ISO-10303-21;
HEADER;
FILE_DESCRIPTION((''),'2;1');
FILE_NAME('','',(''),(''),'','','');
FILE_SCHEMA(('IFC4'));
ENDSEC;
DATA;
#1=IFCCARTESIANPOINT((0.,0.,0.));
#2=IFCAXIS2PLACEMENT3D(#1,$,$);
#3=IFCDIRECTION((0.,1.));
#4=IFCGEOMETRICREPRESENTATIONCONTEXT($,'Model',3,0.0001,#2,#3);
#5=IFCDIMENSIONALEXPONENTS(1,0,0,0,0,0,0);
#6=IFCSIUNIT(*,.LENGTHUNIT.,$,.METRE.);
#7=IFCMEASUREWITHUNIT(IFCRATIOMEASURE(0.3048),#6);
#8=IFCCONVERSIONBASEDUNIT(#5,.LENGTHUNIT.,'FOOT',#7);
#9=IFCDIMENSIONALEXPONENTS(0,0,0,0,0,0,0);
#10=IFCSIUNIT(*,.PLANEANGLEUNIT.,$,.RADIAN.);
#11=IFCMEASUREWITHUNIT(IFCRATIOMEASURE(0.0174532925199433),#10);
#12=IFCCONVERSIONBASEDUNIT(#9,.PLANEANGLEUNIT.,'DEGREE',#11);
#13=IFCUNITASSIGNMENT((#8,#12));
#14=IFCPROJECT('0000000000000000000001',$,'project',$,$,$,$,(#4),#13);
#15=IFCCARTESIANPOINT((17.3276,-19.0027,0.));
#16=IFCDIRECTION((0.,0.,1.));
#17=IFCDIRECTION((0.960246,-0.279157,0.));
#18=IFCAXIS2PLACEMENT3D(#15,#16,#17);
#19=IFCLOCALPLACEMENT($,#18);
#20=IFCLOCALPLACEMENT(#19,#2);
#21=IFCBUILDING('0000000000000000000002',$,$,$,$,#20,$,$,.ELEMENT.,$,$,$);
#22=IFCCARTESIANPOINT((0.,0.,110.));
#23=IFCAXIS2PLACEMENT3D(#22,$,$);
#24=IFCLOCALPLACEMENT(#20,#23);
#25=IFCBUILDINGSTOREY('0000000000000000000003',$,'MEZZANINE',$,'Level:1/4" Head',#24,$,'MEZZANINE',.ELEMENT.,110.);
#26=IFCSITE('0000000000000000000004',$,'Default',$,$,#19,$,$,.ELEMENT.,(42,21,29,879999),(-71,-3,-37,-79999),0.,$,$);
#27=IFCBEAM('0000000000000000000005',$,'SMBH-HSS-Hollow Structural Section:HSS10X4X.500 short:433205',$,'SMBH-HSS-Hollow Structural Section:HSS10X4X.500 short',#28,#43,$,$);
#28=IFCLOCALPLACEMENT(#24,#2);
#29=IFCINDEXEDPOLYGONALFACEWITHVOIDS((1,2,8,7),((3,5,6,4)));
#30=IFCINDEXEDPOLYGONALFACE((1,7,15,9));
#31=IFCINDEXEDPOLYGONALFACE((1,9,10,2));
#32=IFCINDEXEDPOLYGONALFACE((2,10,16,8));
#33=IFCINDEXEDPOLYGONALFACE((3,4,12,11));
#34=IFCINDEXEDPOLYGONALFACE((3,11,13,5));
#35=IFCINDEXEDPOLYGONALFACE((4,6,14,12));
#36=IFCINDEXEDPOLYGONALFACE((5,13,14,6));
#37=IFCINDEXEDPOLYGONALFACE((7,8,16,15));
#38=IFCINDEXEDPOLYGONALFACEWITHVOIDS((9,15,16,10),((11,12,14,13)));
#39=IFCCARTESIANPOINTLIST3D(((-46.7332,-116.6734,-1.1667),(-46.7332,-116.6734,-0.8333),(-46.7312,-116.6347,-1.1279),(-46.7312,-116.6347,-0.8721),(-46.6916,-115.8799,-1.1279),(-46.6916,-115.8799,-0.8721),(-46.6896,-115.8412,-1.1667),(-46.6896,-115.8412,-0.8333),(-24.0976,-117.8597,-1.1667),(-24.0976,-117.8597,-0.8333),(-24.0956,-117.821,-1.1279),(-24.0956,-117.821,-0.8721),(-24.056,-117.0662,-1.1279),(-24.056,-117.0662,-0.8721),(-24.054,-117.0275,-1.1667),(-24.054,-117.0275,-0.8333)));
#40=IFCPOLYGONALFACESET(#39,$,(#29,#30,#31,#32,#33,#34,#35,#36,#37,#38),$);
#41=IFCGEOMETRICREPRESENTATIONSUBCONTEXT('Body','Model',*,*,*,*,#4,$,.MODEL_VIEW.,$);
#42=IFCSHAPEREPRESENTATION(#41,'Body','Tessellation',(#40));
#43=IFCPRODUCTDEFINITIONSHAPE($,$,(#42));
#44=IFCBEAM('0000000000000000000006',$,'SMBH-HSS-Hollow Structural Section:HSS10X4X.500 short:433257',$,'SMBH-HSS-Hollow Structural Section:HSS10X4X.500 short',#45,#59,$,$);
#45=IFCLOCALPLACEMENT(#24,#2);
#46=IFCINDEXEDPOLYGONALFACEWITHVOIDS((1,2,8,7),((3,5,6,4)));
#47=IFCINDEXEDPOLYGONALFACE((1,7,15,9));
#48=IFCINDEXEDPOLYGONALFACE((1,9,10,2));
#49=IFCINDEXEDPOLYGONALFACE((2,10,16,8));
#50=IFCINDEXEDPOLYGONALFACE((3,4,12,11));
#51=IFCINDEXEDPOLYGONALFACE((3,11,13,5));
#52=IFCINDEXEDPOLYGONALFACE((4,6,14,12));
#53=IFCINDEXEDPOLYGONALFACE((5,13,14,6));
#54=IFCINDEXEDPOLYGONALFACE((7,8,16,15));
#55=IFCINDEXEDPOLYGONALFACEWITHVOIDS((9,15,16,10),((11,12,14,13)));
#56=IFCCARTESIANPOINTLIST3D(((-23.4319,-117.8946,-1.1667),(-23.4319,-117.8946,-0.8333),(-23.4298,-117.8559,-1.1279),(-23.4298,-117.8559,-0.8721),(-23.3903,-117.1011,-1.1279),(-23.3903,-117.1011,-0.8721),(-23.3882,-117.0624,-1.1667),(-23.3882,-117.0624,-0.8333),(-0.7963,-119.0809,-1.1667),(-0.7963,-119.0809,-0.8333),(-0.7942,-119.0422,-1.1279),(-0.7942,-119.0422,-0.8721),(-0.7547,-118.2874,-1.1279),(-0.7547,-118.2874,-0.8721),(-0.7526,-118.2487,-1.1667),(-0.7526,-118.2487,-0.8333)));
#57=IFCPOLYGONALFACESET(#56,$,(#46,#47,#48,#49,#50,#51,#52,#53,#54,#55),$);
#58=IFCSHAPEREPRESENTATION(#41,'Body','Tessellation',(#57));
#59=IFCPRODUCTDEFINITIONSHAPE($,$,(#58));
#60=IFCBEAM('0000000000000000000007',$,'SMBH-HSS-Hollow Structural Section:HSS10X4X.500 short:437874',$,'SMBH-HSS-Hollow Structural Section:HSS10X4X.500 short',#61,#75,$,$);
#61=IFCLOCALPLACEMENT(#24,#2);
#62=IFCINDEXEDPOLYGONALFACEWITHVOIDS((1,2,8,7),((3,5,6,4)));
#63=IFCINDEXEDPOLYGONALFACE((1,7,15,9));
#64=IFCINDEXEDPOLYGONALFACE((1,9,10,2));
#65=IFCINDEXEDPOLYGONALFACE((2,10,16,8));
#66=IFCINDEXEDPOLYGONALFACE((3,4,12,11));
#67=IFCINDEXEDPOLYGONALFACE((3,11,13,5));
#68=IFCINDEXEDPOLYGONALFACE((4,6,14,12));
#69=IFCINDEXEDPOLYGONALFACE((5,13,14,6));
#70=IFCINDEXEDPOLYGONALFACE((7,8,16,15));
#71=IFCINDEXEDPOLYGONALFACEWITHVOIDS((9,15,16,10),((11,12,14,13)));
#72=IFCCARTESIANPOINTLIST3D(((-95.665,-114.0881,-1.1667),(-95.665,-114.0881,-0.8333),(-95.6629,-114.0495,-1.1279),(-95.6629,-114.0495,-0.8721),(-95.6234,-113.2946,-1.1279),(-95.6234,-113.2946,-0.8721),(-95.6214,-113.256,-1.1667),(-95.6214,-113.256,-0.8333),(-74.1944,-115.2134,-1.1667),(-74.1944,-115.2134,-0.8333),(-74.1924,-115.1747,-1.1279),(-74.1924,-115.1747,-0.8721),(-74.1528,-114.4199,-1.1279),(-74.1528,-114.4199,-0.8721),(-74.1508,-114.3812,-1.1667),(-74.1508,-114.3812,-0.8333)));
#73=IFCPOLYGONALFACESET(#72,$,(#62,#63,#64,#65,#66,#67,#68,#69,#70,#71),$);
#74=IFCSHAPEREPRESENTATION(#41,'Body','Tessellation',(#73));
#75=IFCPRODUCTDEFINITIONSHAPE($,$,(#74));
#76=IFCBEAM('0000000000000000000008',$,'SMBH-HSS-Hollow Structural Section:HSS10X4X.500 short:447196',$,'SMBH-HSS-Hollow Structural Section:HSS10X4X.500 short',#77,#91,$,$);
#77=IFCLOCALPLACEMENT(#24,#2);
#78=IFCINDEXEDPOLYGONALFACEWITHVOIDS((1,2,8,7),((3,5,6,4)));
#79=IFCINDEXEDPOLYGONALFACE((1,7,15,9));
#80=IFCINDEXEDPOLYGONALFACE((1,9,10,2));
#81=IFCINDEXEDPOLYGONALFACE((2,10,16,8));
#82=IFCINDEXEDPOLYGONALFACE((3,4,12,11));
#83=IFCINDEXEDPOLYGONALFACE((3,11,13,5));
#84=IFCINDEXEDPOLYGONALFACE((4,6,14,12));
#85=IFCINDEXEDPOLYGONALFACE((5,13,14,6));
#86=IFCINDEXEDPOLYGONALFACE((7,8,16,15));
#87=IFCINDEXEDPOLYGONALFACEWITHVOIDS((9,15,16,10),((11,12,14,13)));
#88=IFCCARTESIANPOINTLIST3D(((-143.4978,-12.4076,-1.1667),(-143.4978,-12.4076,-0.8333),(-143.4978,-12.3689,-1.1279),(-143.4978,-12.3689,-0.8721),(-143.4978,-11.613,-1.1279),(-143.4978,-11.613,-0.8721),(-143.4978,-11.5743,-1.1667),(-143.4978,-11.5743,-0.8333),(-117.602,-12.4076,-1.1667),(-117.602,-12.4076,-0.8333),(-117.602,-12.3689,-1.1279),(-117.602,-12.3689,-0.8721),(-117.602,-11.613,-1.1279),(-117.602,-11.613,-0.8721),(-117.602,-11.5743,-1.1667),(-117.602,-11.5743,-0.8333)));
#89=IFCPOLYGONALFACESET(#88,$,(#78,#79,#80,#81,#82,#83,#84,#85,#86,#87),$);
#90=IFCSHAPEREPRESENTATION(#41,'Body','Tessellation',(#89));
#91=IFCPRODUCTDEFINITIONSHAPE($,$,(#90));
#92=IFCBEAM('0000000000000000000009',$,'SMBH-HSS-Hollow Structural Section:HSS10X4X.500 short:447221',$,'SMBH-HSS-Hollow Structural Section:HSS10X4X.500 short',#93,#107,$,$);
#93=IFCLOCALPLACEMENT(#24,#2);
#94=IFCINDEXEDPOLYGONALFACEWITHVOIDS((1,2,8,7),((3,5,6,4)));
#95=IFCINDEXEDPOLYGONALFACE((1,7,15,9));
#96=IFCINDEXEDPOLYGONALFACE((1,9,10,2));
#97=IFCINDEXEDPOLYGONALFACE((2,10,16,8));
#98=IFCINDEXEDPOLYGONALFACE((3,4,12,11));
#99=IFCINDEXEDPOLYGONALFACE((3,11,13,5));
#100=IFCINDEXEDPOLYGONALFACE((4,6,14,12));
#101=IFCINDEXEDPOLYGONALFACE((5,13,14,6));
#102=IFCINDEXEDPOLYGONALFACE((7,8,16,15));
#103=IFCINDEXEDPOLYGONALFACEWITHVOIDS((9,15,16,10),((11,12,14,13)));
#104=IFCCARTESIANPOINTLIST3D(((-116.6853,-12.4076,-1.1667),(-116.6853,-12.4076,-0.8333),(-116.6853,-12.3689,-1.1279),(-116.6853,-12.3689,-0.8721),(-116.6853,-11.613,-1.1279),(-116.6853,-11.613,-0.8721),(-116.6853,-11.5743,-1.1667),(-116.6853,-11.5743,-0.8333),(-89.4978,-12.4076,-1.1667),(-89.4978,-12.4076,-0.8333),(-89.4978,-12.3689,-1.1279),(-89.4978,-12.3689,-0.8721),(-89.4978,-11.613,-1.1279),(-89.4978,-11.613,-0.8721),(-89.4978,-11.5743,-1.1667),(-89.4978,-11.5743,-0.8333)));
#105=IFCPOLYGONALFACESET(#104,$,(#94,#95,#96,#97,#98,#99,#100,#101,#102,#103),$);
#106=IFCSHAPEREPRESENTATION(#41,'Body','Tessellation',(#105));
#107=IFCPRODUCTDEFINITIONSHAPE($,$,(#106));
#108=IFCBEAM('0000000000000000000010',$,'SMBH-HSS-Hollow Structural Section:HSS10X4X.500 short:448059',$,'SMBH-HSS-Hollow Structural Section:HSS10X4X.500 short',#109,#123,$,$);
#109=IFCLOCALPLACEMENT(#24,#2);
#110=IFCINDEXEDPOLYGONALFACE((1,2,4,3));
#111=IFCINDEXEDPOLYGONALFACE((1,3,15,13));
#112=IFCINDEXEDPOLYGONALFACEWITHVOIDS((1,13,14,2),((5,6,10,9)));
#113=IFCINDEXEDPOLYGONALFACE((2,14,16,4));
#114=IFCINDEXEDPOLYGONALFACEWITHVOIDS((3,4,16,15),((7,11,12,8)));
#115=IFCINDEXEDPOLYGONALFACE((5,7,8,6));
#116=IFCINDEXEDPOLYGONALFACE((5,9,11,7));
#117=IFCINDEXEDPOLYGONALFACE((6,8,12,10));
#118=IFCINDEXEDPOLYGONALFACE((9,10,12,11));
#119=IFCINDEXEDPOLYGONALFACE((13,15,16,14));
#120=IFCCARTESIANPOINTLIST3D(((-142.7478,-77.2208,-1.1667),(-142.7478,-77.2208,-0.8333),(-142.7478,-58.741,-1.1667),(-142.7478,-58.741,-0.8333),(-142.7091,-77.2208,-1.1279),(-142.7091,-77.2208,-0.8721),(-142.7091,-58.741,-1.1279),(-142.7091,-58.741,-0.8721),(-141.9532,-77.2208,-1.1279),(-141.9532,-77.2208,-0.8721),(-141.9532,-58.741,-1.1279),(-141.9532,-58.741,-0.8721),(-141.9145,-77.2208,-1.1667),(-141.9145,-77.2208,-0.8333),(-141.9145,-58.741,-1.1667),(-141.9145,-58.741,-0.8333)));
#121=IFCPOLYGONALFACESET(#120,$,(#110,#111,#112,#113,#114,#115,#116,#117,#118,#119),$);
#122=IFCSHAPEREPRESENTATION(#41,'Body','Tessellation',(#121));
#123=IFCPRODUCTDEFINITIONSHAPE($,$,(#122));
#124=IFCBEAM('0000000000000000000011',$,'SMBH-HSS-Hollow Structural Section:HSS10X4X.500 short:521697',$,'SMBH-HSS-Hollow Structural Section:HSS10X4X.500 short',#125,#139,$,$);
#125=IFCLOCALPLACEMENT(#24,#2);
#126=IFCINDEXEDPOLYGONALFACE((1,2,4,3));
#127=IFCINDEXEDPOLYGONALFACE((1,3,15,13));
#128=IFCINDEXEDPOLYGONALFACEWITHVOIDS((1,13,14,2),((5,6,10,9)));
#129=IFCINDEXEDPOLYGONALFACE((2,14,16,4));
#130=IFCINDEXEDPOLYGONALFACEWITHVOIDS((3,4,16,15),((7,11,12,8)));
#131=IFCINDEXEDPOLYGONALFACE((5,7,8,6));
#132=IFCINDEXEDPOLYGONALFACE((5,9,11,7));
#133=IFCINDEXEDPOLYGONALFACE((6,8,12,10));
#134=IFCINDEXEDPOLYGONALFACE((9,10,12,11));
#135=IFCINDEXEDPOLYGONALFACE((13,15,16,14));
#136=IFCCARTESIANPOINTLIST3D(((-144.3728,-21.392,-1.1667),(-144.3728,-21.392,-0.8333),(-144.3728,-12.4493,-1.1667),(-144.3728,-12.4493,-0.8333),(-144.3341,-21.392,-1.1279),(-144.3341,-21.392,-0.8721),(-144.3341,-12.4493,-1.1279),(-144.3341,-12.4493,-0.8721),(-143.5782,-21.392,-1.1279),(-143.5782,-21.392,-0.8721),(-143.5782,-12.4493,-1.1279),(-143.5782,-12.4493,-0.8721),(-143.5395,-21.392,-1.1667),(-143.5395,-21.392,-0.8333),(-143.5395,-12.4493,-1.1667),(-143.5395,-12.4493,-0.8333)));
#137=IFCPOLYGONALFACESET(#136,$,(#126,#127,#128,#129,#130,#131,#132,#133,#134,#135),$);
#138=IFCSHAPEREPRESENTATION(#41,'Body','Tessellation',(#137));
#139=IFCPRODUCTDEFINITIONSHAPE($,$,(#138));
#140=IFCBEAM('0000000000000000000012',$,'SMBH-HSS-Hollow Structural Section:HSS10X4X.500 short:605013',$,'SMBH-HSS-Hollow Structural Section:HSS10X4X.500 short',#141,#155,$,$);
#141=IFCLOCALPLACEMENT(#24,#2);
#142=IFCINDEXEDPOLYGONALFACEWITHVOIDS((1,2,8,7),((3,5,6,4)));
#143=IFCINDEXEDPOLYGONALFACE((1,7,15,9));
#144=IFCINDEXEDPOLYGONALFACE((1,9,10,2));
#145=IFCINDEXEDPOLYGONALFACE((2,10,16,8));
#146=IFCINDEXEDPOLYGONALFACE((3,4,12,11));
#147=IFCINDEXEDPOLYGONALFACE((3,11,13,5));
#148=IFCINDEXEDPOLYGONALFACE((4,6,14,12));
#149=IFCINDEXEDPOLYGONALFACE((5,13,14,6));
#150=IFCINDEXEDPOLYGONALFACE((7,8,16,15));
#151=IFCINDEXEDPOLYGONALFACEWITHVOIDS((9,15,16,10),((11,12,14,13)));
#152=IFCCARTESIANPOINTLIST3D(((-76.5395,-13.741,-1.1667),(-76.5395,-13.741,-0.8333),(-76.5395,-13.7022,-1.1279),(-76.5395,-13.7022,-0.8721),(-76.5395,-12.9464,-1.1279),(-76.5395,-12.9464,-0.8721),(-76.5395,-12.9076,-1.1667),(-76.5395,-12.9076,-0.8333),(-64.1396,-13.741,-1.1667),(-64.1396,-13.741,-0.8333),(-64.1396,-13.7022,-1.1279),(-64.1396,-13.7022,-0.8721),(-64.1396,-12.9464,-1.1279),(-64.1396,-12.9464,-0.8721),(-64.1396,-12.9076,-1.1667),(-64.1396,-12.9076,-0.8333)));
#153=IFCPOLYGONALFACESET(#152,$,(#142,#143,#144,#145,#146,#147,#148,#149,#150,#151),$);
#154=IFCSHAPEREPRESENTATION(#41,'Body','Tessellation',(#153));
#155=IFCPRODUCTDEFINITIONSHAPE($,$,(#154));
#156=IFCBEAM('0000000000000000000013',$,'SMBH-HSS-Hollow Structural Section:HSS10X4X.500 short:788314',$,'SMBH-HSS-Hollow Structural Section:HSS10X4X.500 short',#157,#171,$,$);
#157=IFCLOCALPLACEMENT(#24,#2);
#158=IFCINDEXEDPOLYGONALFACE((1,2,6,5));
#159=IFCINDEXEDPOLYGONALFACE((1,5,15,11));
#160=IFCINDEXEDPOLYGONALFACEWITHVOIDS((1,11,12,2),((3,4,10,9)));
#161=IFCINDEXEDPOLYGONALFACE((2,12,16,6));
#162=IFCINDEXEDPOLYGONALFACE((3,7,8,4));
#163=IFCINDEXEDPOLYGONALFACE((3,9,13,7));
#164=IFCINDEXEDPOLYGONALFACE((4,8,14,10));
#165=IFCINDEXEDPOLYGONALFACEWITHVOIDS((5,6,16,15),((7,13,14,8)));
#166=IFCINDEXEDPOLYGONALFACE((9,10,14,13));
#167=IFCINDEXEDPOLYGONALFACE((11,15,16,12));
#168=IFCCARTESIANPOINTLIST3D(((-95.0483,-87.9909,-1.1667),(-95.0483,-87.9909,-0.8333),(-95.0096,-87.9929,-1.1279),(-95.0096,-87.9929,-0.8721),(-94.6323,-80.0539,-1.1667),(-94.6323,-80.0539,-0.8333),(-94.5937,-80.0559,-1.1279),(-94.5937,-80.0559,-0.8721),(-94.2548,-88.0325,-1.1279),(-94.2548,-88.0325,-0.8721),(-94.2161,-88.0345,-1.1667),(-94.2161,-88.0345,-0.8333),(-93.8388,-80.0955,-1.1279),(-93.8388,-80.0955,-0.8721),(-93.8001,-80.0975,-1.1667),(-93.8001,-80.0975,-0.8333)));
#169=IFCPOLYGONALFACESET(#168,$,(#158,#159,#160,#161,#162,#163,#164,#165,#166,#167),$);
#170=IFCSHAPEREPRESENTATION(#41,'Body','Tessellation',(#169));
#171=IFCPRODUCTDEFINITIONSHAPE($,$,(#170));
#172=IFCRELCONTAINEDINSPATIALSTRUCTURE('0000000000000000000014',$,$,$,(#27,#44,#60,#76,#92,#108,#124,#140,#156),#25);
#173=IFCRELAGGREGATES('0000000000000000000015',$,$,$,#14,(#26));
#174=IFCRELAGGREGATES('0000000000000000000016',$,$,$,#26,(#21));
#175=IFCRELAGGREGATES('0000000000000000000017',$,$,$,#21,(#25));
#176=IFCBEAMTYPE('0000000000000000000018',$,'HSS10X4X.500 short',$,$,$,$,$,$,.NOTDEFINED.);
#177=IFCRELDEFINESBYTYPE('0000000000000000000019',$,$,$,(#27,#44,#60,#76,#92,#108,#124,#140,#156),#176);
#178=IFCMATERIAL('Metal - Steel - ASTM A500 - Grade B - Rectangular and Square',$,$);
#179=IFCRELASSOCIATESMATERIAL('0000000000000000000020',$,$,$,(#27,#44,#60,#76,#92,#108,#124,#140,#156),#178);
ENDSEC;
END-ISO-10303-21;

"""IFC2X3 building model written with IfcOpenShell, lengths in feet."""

from ifc_helpers import new_model, entity, si_unit, converted_unit, direction, frame, frame_2d, origin, place, context, subcontext, project, spatial, rectangle, extrude, boolean, material, type_object, element, save


model = new_model("IFC2X3")

# Units and contexts
model_context = context("Model", 3, precision=0.0001, world=origin(), true_north=direction((0.0, 1.0)))
body_context = subcontext(model_context, "Body", "Model", "MODEL_VIEW")
ifc_project = project(units=[converted_unit("LENGTHUNIT", "FOOT", entity("IfcRatioMeasure", 0.3048), si_unit("LENGTHUNIT", "METRE"), dimensions=[1, 0, 0, 0, 0, 0, 0]), converted_unit("PLANEANGLEUNIT", "DEGREE", entity("IfcRatioMeasure", 0.0174532925199433), si_unit("PLANEANGLEUNIT", "RADIAN"), dimensions=[0, 0, 0, 0, 0, 0, 0])], contexts=[model_context])

# Site, building, storey
site_placement = place(None, frame((17.3276, -19.0027, 0.0), z_axis=(0.0, 0.0, 1.0), x_axis=(0.960246, -0.279157, 0.0)))
site = spatial("IfcSite", under=ifc_project, at=site_placement, Name="Default", CompositionType="ELEMENT", RefLatitude=(42, 21, 29, 879999), RefLongitude=(-71, -3, -37, -79999), RefElevation=0.0)
building_placement = place(site_placement, origin())
building = spatial("IfcBuilding", under=site, at=building_placement, CompositionType="ELEMENT")
storey_placement = place(building_placement, frame((0.0, 0.0, 110.0)))
storey = spatial("IfcBuildingStorey", under=building, at=storey_placement, Name="MEZZANINE", ObjectType="Level:1/4\" Head", LongName="MEZZANINE", CompositionType="ELEMENT", Elevation=110.0)

# Beams
ifc_material_1 = material(Name="Metal - Steel - ASTM A500 - Grade B - Rectangular and Square")
beam_type_1 = type_object("IfcBeamType", Name="HSS10X4X.500 short", PredefinedType="NOTDEFINED")
beam_1_placement = place(storey_placement, frame((-47.0443, -116.2399, -0.8333), z_axis=(0.0, 0.0, 1.0), x_axis=(0.99863, -0.052336, 0.0)))
element("IfcBeam", 1, at=beam_1_placement, inside=storey, type_object=beam_type_1, material=ifc_material_1, Name="SMBH-HSS-Hollow Structural Section:HSS10X4X.500 short:433205", ObjectType="SMBH-HSS-Hollow Structural Section:HSS10X4X.500 short", context=body_context, shape_type="SweptSolid", body=[
    boolean("DIFFERENCE", extrude(rectangle(XDim=0.3333, YDim=0.8333, at=frame_2d((0.0, 0.0), x_axis=(1.0, 0.0))), frame((0.3333, 0.0, -0.1667), z_axis=(1.0, 0.0, 0.0), x_axis=(0.0, 0.0, -1.0)), (0.0, 0.0, 1.0), 22.6667), extrude(rectangle(XDim=0.2559, YDim=0.7559, at=frame_2d((0.0, 0.0), x_axis=(0.0, 1.0))), frame((23.0, 0.0, -0.1667), z_axis=(-1.0, 0.0, 0.0), x_axis=(0.0, 1.0, 0.0)), (0.0, 0.0, 1.0), 22.6667)),
])
beam_2_placement = place(storey_placement, frame((-23.7429, -117.461, -0.8333), z_axis=(0.0, 0.0, 1.0), x_axis=(0.99863, -0.052336, 0.0)))
element("IfcBeam", 2, at=beam_2_placement, inside=storey, type_object=beam_type_1, material=ifc_material_1, Name="SMBH-HSS-Hollow Structural Section:HSS10X4X.500 short:433257", ObjectType="SMBH-HSS-Hollow Structural Section:HSS10X4X.500 short", context=body_context, shape_type="SweptSolid", body=[
    boolean("DIFFERENCE", extrude(rectangle(XDim=0.3333, YDim=0.8333, at=frame_2d((0.0, 0.0), x_axis=(1.0, 0.0))), frame((0.3333, 0.0, -0.1667), z_axis=(1.0, 0.0, 0.0), x_axis=(0.0, 0.0, -1.0)), (0.0, 0.0, 1.0), 22.6667), extrude(rectangle(XDim=0.2559, YDim=0.7559, at=frame_2d((0.0, 0.0), x_axis=(0.0, 1.0))), frame((23.0, 0.0, -0.1667), z_axis=(-1.0, 0.0, 0.0), x_axis=(0.0, 1.0, 0.0)), (0.0, 0.0, 1.0), 22.6667)),
])
beam_3_placement = place(storey_placement, frame((-95.976, -113.6546, -0.8333), z_axis=(0.0, 0.0, 1.0), x_axis=(0.99863, -0.052336, 0.0)))
element("IfcBeam", 3, at=beam_3_placement, inside=storey, type_object=beam_type_1, material=ifc_material_1, Name="SMBH-HSS-Hollow Structural Section:HSS10X4X.500 short:437874", ObjectType="SMBH-HSS-Hollow Structural Section:HSS10X4X.500 short", context=body_context, shape_type="SweptSolid", body=[
    boolean("DIFFERENCE", extrude(rectangle(XDim=0.3333, YDim=0.8333, at=frame_2d((0.0, 0.0), x_axis=(1.0, 0.0))), frame((0.3333, 0.0, -0.1667), z_axis=(1.0, 0.0, 0.0), x_axis=(0.0, 0.0, -1.0)), (0.0, 0.0, 1.0), 21.5), extrude(rectangle(XDim=0.2559, YDim=0.7559, at=frame_2d((0.0, 0.0), x_axis=(0.0, 1.0))), frame((21.8333, 0.0, -0.1667), z_axis=(-1.0, 0.0, 0.0), x_axis=(0.0, 1.0, 0.0)), (0.0, 0.0, 1.0), 21.5)),
])
beam_4_placement = place(storey_placement, frame((-143.5395, -11.991, -0.8333)))
element("IfcBeam", 4, at=beam_4_placement, inside=storey, type_object=beam_type_1, material=ifc_material_1, Name="SMBH-HSS-Hollow Structural Section:HSS10X4X.500 short:447196", ObjectType="SMBH-HSS-Hollow Structural Section:HSS10X4X.500 short", context=body_context, shape_type="SweptSolid", body=[
    boolean("DIFFERENCE", extrude(rectangle(XDim=0.3333, YDim=0.8333, at=frame_2d((0.0, 0.0), x_axis=(1.0, 0.0))), frame((0.0417, 0.0, -0.1667), z_axis=(1.0, 0.0, 0.0), x_axis=(0.0, 0.0, -1.0)), (0.0, 0.0, 1.0), 25.8958), extrude(rectangle(XDim=0.2559, YDim=0.7559, at=frame_2d((0.0, 0.0), x_axis=(0.0, 1.0))), frame((25.9375, 0.0, -0.1667), z_axis=(-1.0, 0.0, 0.0), x_axis=(0.0, 1.0, 0.0)), (0.0, 0.0, 1.0), 25.8958)),
])
beam_5_placement = place(storey_placement, frame((-116.9978, -11.991, -0.8333)))
element("IfcBeam", 5, at=beam_5_placement, inside=storey, type_object=beam_type_1, material=ifc_material_1, Name="SMBH-HSS-Hollow Structural Section:HSS10X4X.500 short:447221", ObjectType="SMBH-HSS-Hollow Structural Section:HSS10X4X.500 short", context=body_context, shape_type="SweptSolid", body=[
    boolean("DIFFERENCE", extrude(rectangle(XDim=0.3333, YDim=0.8333, at=frame_2d((0.0, 0.0), x_axis=(1.0, 0.0))), frame((0.3125, 0.0, -0.1667), z_axis=(1.0, 0.0, 0.0), x_axis=(0.0, 0.0, -1.0)), (0.0, 0.0, 1.0), 27.1875), extrude(rectangle(XDim=0.2559, YDim=0.7559, at=frame_2d((0.0, 0.0), x_axis=(0.0, 1.0))), frame((27.5, 0.0, -0.1667), z_axis=(-1.0, 0.0, 0.0), x_axis=(0.0, 1.0, 0.0)), (0.0, 0.0, 1.0), 27.1875)),
])
beam_6_placement = place(storey_placement, frame((-142.3312, -77.4755, -0.8333), z_axis=(0.0, 0.0, 1.0), x_axis=(0.0, 1.0, 0.0)))
element("IfcBeam", 6, at=beam_6_placement, inside=storey, type_object=beam_type_1, material=ifc_material_1, Name="SMBH-HSS-Hollow Structural Section:HSS10X4X.500 short:448059", ObjectType="SMBH-HSS-Hollow Structural Section:HSS10X4X.500 short", context=body_context, shape_type="SweptSolid", body=[
    boolean("DIFFERENCE", extrude(rectangle(XDim=0.3333, YDim=0.8333, at=frame_2d((0.0, 0.0), x_axis=(1.0, 0.0))), frame((0.2547, 0.0, -0.1667), z_axis=(1.0, 0.0, 0.0), x_axis=(0.0, 0.0, -1.0)), (0.0, 0.0, 1.0), 18.4798), extrude(rectangle(XDim=0.2559, YDim=0.7559, at=frame_2d((0.0, 0.0), x_axis=(0.0, 1.0))), frame((18.7345, 0.0, -0.1667), z_axis=(-1.0, 0.0, 0.0), x_axis=(0.0, 1.0, 0.0)), (0.0, 0.0, 1.0), 18.4798)),
])
beam_7_placement = place(storey_placement, frame((-143.9562, -21.392, -0.8333), z_axis=(0.0, 0.0, 1.0), x_axis=(0.0, 1.0, 0.0)))
element("IfcBeam", 7, at=beam_7_placement, inside=storey, type_object=beam_type_1, material=ifc_material_1, Name="SMBH-HSS-Hollow Structural Section:HSS10X4X.500 short:521697", ObjectType="SMBH-HSS-Hollow Structural Section:HSS10X4X.500 short", context=body_context, shape_type="SweptSolid", body=[
    boolean("DIFFERENCE", extrude(rectangle(XDim=0.3333, YDim=0.8333, at=frame_2d((0.0, 0.0), x_axis=(1.0, 0.0))), frame((0.0, 0.0, -0.1667), z_axis=(1.0, 0.0, 0.0), x_axis=(0.0, 0.0, -1.0)), (0.0, 0.0, 1.0), 8.9427), extrude(rectangle(XDim=0.2559, YDim=0.7559, at=frame_2d((0.0, 0.0), x_axis=(0.0, 1.0))), frame((8.9427, 0.0, -0.1667), z_axis=(-1.0, 0.0, 0.0), x_axis=(0.0, 1.0, 0.0)), (0.0, 0.0, 1.0), 8.9427)),
])
beam_8_placement = place(storey_placement, frame((-76.7478, -13.3243, -0.8333)))
element("IfcBeam", 8, at=beam_8_placement, inside=storey, type_object=beam_type_1, material=ifc_material_1, Name="SMBH-HSS-Hollow Structural Section:HSS10X4X.500 short:605013", ObjectType="SMBH-HSS-Hollow Structural Section:HSS10X4X.500 short", context=body_context, shape_type="SweptSolid", body=[
    boolean("DIFFERENCE", extrude(rectangle(XDim=0.3333, YDim=0.8333, at=frame_2d((0.0, 0.0), x_axis=(1.0, 0.0))), frame((0.2083, 0.0, -0.1667), z_axis=(1.0, 0.0, 0.0), x_axis=(0.0, 0.0, -1.0)), (0.0, 0.0, 1.0), 12.3999), extrude(rectangle(XDim=0.2559, YDim=0.7559, at=frame_2d((0.0, 0.0), x_axis=(0.0, 1.0))), frame((12.6083, 0.0, -0.1667), z_axis=(-1.0, 0.0, 0.0), x_axis=(0.0, 1.0, 0.0)), (0.0, 0.0, 1.0), 12.3999)),
])
beam_9_placement = place(storey_placement, frame((-94.6431, -88.2208, -0.8333), z_axis=(0.0, 0.0, 1.0), x_axis=(0.052336, 0.99863, 0.0)))
element("IfcBeam", 9, at=beam_9_placement, inside=storey, type_object=beam_type_1, material=ifc_material_1, Name="SMBH-HSS-Hollow Structural Section:HSS10X4X.500 short:788314", ObjectType="SMBH-HSS-Hollow Structural Section:HSS10X4X.500 short", context=body_context, shape_type="SweptSolid", body=[
    boolean("DIFFERENCE", extrude(rectangle(XDim=0.3333, YDim=0.8333, at=frame_2d((0.0, 0.0), x_axis=(1.0, 0.0))), frame((0.2083, 0.0, -0.1667), z_axis=(1.0, 0.0, 0.0), x_axis=(0.0, 0.0, -1.0)), (0.0, 0.0, 1.0), 7.9479), extrude(rectangle(XDim=0.2559, YDim=0.7559, at=frame_2d((0.0, 0.0), x_axis=(0.0, 1.0))), frame((8.1562, 0.0, -0.1667), z_axis=(-1.0, 0.0, 0.0), x_axis=(0.0, 1.0, 0.0)), (0.0, 0.0, 1.0), 7.9479)),
])

save(model, "model.ifc")
